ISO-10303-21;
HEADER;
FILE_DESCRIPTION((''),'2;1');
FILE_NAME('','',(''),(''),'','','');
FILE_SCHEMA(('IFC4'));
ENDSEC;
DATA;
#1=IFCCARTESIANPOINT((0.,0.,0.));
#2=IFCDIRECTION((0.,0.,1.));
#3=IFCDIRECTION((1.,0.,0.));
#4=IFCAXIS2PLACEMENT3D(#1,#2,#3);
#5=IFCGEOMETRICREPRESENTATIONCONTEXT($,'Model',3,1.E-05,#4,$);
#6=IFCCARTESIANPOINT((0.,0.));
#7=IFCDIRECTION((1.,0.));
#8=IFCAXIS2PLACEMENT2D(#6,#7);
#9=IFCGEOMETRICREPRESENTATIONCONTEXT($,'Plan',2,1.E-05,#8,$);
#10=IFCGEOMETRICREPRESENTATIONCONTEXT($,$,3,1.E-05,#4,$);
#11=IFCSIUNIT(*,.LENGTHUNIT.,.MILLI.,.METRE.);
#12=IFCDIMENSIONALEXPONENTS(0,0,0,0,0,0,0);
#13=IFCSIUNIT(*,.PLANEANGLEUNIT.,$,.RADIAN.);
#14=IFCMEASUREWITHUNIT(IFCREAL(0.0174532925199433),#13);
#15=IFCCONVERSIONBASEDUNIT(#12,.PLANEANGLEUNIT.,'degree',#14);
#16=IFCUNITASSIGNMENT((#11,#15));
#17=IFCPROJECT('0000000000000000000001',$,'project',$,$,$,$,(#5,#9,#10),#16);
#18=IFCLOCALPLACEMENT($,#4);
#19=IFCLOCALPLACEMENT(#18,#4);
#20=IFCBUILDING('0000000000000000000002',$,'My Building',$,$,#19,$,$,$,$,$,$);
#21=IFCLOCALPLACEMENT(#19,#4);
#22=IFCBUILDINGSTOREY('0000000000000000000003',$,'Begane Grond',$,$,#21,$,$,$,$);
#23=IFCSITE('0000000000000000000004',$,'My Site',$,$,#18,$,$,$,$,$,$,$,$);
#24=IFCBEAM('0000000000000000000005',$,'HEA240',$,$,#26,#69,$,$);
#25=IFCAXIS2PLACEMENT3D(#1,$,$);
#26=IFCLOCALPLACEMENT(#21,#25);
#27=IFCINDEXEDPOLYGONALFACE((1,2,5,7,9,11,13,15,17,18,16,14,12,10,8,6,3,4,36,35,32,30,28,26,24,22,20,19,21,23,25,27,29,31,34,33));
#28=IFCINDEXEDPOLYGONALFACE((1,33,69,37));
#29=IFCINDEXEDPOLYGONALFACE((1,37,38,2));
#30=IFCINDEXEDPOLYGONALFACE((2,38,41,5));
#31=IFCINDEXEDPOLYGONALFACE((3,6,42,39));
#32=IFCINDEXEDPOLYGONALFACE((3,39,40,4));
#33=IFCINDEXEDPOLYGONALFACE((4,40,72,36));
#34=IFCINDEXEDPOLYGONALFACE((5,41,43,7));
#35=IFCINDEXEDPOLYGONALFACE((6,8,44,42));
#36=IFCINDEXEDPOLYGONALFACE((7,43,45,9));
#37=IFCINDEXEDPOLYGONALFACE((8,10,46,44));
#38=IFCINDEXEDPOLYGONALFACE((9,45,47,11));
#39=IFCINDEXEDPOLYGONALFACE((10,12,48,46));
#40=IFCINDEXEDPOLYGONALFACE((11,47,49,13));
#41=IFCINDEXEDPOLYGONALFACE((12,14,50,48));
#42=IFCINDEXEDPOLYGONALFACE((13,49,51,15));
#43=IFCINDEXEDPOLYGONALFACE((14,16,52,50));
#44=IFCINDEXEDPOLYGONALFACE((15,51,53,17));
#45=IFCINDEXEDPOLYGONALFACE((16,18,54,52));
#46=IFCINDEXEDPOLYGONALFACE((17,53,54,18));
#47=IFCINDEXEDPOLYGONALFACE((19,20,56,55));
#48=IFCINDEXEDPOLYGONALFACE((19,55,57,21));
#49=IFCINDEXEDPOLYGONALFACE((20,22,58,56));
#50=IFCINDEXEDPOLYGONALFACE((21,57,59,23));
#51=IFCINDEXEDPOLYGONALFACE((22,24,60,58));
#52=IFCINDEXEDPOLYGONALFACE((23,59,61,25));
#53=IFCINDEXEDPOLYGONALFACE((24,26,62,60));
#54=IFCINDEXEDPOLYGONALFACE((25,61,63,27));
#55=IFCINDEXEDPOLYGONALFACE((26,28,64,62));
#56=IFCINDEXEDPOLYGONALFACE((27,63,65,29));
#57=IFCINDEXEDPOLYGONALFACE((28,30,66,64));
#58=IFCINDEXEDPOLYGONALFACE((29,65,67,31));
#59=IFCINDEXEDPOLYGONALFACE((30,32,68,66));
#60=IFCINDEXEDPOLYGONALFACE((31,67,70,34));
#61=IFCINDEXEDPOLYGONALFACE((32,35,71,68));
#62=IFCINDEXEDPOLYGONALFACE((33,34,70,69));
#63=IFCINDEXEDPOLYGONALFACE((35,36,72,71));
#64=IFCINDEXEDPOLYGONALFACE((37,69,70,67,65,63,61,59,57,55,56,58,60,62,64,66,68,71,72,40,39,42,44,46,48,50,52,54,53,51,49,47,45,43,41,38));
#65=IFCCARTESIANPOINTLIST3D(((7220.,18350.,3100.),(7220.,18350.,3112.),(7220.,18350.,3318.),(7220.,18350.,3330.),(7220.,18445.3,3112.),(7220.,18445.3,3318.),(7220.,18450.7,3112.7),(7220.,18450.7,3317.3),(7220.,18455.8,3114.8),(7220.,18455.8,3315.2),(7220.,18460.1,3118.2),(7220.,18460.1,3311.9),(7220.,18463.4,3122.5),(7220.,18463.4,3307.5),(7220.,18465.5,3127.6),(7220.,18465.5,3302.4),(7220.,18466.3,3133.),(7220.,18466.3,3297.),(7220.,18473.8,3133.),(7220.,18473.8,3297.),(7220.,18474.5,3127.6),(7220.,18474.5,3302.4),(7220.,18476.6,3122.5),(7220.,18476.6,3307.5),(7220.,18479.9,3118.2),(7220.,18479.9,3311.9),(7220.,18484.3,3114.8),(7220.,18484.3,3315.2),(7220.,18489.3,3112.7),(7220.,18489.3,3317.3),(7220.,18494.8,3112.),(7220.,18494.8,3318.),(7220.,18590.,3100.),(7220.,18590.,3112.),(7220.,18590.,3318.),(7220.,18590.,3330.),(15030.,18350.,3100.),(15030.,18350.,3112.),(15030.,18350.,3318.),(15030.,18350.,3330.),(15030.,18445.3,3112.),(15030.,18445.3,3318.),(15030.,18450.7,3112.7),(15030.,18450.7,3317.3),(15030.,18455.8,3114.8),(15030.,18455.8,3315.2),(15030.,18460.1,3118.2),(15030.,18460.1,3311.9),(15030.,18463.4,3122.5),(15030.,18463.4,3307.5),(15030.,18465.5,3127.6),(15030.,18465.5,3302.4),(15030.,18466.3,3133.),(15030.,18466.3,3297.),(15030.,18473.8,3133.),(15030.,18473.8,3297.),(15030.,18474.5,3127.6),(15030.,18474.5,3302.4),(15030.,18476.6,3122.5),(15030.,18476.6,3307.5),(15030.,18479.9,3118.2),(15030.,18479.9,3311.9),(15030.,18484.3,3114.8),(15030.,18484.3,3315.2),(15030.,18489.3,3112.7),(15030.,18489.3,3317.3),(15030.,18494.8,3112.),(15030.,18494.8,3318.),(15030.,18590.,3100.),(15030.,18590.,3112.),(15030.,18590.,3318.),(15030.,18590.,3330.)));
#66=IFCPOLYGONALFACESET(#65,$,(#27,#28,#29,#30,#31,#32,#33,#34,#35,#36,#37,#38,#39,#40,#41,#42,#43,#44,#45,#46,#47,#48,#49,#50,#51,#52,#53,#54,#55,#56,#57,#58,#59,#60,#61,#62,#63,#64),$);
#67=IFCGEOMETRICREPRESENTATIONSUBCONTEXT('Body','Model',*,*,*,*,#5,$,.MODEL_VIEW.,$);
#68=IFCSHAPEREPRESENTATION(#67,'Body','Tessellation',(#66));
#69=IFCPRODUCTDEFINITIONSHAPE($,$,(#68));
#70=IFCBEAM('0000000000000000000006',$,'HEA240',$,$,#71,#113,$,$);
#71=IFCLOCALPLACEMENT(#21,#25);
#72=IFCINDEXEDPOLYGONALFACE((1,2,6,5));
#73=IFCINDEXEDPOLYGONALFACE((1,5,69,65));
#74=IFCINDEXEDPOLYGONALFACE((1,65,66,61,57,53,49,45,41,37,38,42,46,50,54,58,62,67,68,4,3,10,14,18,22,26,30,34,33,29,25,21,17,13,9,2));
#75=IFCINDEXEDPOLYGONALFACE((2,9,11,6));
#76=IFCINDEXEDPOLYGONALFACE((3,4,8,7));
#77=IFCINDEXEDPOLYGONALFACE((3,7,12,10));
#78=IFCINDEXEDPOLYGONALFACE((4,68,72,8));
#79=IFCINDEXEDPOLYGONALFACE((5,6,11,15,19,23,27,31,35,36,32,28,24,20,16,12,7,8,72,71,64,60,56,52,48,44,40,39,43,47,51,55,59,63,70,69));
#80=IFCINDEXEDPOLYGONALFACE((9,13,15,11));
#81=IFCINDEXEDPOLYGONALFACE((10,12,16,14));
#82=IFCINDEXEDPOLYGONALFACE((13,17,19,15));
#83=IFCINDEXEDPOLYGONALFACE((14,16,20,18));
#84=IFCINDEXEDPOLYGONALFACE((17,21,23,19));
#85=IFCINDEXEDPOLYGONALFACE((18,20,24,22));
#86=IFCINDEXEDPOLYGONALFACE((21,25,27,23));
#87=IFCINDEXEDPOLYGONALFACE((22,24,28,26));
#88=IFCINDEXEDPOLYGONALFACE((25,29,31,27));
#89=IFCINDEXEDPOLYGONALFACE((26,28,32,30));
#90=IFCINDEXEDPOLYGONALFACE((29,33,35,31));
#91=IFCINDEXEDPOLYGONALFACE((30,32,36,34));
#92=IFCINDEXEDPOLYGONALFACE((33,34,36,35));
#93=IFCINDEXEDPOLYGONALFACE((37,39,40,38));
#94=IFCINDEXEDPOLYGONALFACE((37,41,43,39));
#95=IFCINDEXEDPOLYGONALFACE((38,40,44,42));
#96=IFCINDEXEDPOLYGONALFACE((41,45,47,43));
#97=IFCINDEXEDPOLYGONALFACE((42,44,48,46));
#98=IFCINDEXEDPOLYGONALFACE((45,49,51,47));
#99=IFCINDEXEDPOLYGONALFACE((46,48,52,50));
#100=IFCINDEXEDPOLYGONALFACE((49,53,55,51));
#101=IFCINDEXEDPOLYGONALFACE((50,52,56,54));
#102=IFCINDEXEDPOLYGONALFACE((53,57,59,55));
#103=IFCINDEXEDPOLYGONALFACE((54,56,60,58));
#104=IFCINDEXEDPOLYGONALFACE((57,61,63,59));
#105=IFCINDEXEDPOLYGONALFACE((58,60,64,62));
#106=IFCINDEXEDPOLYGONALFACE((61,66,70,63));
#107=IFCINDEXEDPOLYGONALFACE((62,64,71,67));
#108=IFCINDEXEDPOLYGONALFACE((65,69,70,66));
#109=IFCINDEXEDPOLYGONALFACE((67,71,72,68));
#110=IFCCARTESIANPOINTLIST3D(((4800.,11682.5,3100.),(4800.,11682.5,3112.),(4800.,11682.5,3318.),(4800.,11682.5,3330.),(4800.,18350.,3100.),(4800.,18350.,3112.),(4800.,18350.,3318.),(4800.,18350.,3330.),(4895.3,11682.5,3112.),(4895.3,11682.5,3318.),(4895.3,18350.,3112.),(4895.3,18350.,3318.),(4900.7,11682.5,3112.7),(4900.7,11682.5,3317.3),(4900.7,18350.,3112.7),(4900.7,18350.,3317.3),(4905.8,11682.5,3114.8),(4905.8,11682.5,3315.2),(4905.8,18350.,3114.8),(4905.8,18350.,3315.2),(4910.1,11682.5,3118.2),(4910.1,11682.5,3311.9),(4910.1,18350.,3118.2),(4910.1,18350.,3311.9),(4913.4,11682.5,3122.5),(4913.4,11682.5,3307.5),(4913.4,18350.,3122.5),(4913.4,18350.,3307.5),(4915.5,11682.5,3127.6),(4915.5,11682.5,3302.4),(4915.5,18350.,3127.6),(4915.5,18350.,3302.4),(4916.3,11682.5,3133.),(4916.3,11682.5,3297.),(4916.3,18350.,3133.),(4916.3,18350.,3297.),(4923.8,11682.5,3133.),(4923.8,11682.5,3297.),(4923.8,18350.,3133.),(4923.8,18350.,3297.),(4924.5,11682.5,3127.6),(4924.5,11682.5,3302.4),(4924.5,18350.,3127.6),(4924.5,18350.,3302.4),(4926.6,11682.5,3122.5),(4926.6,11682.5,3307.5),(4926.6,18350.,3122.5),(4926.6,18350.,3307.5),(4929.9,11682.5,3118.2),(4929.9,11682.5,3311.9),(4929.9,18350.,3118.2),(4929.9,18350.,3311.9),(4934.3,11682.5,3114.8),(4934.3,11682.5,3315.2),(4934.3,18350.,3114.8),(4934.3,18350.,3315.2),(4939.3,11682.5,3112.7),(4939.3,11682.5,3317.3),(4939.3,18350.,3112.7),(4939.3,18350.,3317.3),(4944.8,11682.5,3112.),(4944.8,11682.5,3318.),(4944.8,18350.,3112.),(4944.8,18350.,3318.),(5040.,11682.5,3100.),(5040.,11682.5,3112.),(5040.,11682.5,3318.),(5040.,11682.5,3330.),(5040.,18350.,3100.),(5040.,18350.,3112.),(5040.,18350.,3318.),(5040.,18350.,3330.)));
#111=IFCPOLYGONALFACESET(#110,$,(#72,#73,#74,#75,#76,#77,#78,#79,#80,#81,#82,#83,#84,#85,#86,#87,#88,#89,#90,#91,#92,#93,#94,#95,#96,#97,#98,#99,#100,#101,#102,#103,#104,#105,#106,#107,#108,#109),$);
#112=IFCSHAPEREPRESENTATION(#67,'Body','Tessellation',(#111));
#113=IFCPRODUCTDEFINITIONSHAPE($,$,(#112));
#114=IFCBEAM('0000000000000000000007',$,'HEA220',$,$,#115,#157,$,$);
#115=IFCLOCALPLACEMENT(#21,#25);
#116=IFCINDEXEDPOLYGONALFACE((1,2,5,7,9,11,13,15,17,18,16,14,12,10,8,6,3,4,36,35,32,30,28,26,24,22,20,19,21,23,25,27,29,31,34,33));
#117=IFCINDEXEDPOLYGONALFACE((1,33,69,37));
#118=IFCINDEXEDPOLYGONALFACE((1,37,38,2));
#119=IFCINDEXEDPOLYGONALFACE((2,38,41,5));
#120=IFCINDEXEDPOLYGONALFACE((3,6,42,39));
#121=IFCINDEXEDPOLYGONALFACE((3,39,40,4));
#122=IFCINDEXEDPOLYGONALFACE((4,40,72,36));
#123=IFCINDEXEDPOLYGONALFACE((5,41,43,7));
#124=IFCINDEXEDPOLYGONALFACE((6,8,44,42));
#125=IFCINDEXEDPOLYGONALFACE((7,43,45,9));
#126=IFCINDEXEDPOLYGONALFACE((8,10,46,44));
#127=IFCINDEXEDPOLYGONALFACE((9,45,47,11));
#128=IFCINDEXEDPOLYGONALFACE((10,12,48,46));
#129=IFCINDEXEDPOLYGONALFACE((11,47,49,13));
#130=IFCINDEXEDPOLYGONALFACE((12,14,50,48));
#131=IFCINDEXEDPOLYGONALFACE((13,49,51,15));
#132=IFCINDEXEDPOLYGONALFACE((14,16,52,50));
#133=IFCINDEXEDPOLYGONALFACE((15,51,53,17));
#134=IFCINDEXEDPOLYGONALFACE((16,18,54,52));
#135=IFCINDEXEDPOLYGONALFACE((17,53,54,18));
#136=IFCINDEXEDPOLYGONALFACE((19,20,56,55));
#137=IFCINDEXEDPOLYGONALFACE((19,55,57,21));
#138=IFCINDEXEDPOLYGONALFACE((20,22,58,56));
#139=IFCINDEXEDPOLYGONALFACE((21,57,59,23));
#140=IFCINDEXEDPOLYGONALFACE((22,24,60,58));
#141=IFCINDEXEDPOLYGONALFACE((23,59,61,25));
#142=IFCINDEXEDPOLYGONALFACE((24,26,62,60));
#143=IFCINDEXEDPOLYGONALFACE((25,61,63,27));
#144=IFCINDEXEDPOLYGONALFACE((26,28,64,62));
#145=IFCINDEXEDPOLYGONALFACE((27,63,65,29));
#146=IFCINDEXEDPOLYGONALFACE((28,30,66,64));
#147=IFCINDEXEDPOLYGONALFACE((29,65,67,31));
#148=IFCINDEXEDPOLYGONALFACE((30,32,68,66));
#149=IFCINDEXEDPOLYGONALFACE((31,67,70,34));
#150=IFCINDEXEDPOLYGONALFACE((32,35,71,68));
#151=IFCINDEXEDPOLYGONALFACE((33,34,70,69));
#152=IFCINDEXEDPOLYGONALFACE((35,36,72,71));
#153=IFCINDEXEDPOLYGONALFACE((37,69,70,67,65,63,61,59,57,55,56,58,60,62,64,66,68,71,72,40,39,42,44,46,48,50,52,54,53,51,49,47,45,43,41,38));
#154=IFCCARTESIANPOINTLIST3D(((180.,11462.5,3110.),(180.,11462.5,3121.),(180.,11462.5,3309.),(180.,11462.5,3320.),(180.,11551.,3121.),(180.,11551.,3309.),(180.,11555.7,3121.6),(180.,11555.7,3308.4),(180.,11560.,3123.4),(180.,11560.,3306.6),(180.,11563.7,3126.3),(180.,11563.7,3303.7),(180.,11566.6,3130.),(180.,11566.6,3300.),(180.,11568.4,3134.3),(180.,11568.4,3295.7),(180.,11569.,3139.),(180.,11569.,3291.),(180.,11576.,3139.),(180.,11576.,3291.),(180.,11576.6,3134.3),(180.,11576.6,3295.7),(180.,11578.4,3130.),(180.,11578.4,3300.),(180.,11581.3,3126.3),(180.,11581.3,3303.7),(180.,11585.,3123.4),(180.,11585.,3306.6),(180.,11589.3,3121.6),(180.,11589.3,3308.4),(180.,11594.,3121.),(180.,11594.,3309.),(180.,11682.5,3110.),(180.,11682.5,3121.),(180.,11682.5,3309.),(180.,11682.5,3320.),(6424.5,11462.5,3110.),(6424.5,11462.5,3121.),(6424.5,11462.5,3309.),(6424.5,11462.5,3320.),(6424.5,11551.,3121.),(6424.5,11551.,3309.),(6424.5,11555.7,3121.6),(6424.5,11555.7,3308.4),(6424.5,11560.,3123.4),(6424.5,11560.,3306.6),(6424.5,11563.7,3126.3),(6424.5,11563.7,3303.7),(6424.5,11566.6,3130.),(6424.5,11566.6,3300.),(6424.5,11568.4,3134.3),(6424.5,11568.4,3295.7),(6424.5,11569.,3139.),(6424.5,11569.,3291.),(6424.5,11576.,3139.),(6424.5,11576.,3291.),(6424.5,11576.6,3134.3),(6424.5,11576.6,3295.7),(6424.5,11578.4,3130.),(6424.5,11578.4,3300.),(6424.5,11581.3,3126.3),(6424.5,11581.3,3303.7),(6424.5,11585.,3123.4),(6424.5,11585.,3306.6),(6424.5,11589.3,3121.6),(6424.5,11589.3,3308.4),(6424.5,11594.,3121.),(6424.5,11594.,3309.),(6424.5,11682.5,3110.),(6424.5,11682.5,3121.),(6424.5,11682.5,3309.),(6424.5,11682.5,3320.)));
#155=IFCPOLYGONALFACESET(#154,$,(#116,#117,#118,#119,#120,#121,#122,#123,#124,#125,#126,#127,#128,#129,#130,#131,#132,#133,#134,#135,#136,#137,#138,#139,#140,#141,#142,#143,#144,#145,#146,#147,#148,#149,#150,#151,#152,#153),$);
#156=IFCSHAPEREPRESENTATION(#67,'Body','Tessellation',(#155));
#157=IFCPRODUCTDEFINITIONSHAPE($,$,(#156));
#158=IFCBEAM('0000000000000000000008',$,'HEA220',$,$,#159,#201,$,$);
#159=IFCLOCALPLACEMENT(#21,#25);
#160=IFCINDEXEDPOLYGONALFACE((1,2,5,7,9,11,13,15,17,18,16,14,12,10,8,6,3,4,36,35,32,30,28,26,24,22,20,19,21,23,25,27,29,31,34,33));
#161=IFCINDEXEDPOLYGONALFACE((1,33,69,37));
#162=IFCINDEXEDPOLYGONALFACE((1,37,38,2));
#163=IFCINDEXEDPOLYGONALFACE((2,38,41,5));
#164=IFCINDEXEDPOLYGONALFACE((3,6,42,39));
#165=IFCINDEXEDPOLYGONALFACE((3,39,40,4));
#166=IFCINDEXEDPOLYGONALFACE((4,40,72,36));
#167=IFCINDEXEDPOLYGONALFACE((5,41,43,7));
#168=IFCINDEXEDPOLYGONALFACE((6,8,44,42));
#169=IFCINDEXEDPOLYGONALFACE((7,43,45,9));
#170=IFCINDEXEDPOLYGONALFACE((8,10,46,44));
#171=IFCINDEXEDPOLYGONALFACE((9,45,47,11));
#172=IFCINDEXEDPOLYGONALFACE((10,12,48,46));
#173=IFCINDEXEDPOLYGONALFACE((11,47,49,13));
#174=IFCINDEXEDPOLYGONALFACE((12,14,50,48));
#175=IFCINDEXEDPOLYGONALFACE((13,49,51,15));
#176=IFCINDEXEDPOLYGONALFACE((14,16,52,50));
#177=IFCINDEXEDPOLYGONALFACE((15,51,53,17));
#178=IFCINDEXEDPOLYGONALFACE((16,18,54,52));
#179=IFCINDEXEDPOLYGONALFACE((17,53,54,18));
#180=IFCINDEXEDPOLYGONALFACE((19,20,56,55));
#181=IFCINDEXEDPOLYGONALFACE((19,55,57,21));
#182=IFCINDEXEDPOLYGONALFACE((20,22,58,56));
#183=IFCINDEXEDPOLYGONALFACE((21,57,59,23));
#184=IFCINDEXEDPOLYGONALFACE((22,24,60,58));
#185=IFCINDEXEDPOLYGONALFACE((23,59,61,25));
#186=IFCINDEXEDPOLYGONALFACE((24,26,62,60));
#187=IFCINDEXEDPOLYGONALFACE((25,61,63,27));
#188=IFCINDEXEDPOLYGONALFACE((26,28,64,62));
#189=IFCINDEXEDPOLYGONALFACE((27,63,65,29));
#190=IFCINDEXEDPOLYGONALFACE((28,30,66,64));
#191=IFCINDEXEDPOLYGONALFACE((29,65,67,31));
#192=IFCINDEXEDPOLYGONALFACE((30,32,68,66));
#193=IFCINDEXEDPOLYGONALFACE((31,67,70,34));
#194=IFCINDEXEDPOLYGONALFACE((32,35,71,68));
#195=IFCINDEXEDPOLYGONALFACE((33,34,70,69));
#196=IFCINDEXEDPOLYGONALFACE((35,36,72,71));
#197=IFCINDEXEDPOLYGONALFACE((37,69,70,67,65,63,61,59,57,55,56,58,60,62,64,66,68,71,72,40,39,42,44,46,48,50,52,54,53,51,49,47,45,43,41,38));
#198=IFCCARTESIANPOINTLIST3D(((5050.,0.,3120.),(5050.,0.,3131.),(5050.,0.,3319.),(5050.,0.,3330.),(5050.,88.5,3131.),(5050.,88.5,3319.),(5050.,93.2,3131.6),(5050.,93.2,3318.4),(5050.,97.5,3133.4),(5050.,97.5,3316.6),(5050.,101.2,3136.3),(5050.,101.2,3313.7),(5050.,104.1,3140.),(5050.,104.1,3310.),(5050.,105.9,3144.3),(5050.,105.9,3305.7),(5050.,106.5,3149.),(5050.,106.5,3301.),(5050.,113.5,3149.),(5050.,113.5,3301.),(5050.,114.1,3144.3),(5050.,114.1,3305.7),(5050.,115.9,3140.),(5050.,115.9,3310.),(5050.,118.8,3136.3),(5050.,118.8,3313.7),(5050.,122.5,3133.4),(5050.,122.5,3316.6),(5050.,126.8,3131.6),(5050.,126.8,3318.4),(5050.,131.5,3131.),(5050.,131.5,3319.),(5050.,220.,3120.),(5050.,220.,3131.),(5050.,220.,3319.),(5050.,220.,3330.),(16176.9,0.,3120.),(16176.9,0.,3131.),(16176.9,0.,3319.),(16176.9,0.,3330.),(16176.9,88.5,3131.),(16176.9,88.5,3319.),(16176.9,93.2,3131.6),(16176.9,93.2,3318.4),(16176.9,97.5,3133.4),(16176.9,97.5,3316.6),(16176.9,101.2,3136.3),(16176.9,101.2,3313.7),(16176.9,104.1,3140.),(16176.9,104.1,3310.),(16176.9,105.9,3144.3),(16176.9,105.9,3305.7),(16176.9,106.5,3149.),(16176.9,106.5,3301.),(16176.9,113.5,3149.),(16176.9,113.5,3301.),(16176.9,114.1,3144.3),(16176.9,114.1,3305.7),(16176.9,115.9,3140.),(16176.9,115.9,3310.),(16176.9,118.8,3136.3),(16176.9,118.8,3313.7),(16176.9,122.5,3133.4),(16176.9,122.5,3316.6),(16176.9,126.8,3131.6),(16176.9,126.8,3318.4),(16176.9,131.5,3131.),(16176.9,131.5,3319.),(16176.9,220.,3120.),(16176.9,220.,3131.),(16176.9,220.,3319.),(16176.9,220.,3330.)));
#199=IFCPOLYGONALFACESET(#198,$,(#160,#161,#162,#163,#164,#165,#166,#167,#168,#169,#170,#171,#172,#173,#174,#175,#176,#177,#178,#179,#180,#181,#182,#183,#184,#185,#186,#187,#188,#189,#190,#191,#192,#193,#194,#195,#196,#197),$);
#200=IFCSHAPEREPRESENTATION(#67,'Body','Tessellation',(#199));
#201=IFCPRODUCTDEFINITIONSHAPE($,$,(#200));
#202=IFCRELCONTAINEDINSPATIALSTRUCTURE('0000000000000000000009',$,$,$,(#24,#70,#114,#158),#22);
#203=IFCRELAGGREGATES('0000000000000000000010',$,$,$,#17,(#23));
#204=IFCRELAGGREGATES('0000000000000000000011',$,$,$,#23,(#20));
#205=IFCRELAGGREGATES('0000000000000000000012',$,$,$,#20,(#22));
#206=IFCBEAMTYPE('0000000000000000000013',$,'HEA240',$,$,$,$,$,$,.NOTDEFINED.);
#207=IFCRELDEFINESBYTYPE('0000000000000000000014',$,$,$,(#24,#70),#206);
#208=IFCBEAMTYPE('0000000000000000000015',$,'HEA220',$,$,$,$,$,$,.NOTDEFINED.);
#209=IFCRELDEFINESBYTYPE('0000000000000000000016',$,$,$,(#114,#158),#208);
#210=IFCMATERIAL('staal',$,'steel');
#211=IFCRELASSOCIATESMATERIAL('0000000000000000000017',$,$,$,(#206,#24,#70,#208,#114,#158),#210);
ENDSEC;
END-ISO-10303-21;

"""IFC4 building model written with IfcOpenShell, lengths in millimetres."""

from ifc_helpers import new_model, entity, si_unit, converted_unit, frame, origin_with_axes, origin_2d_with_axis, place, context, subcontext, project, spatial, i_section, extrude, material, material_profile, profile_set, profile_usage, type_object, element, save


model = new_model("IFC4")

# Units and contexts
model_context = context("Model", 3, precision=1e-05, world=origin_with_axes())
plan_context = context("Plan", 2, precision=1e-05, world=origin_2d_with_axis())
context_of_model = context(None, 3, precision=1e-05, world=origin_with_axes())
body_context = subcontext(model_context, "Body", "Model", "MODEL_VIEW")
ifc_project = project(units=[si_unit("LENGTHUNIT", "METRE", prefix="MILLI"), converted_unit("PLANEANGLEUNIT", "degree", entity("IfcReal", 0.0174532925199433), si_unit("PLANEANGLEUNIT", "RADIAN"), dimensions=[0, 0, 0, 0, 0, 0, 0])], contexts=[model_context, plan_context, context_of_model])

# Site, building, storey
site_placement = place(None, origin_with_axes())
site = spatial("IfcSite", under=ifc_project, at=site_placement, Name="My Site")
building_placement = place(site_placement, origin_with_axes())
building = spatial("IfcBuilding", under=site, at=building_placement, Name="My Building")
storey_placement = place(building_placement, origin_with_axes())
storey = spatial("IfcBuildingStorey", under=building, at=storey_placement, Name="Begane Grond")

# Shared definitions
ifc_material = material(Name="staal", Category="steel")

# Beams
ifc_material_profile_1 = material_profile(ifc_material, i_section(OverallWidth=240.0, OverallDepth=230.0, WebThickness=7.5, FlangeThickness=12.0, FilletRadius=21.0))
ifc_profile_set_1 = profile_set([ifc_material_profile_1], Name="HEA240")
beam_type_1 = type_object("IfcBeamType", Name="HEA240", PredefinedType="NOTDEFINED", material=ifc_profile_set_1)
ifc_profile_usage_1 = profile_usage(ifc_profile_set_1, cardinal=5)
beam_1_placement = place(storey_placement, frame((7220.0, 18470.0, 3215.0), z_axis=(1.0, 0.0, 0.0), x_axis=(0.0, 1.0, 0.0)))
element("IfcBeam", 1, at=beam_1_placement, inside=storey, type_object=beam_type_1, material=ifc_profile_usage_1, Name="HEA240", context=body_context, shape_type="SweptSolid", body=[
    extrude(i_section(OverallWidth=240.0, OverallDepth=230.0, WebThickness=7.5, FlangeThickness=12.0, FilletRadius=21.0), origin_with_axes(), (0.0, 0.0, 1.0), 7810.0),
])
ifc_profile_usage_2 = profile_usage(ifc_profile_set_1, cardinal=5)
beam_2_placement = place(storey_placement, frame((4920.0, 18350.0, 3215.0), z_axis=(0.0, -1.0, 0.0), x_axis=(1.0, 0.0, 0.0)))
element("IfcBeam", 2, at=beam_2_placement, inside=storey, type_object=beam_type_1, material=ifc_profile_usage_2, Name="HEA240", context=body_context, shape_type="SweptSolid", body=[
    extrude(i_section(OverallWidth=240.0, OverallDepth=230.0, WebThickness=7.5, FlangeThickness=12.0, FilletRadius=21.0), origin_with_axes(), (0.0, 0.0, 1.0), 6667.5),
])
ifc_material_profile_2 = material_profile(ifc_material, i_section(OverallWidth=220.0, OverallDepth=210.0, WebThickness=7.0, FlangeThickness=11.0, FilletRadius=18.0))
ifc_profile_set_2 = profile_set([ifc_material_profile_2], Name="HEA220")
ifc_profile_usage_3 = profile_usage(ifc_profile_set_2)
beam_type_2 = type_object("IfcBeamType", Name="HEA220", PredefinedType="NOTDEFINED", material=ifc_profile_set_2)
beam_3_placement = place(storey_placement, frame((180.0, 11572.5, 3215.0), z_axis=(1.0, 0.0, 0.0), x_axis=(0.0, 1.0, 0.0)))
element("IfcBeam", 3, at=beam_3_placement, inside=storey, type_object=beam_type_2, material=ifc_profile_usage_3, Name="HEA220", context=body_context, shape_type="SweptSolid", body=[
    extrude(i_section(OverallWidth=220.0, OverallDepth=210.0, WebThickness=7.0, FlangeThickness=11.0, FilletRadius=18.0), origin_with_axes(), (0.0, 0.0, 1.0), 6244.5),
])
ifc_profile_usage_4 = profile_usage(ifc_profile_set_2)
beam_4_placement = place(storey_placement, frame((5050.0, 110.0, 3225.0), z_axis=(1.0, 0.0, 0.0), x_axis=(0.0, 1.0, 0.0)))
element("IfcBeam", 4, at=beam_4_placement, inside=storey, type_object=beam_type_2, material=ifc_profile_usage_4, Name="HEA220", context=body_context, shape_type="SweptSolid", body=[
    extrude(i_section(OverallWidth=220.0, OverallDepth=210.0, WebThickness=7.0, FlangeThickness=11.0, FilletRadius=18.0), origin_with_axes(), (0.0, 0.0, 1.0), 11126.9),
])

save(model, "model.ifc")
